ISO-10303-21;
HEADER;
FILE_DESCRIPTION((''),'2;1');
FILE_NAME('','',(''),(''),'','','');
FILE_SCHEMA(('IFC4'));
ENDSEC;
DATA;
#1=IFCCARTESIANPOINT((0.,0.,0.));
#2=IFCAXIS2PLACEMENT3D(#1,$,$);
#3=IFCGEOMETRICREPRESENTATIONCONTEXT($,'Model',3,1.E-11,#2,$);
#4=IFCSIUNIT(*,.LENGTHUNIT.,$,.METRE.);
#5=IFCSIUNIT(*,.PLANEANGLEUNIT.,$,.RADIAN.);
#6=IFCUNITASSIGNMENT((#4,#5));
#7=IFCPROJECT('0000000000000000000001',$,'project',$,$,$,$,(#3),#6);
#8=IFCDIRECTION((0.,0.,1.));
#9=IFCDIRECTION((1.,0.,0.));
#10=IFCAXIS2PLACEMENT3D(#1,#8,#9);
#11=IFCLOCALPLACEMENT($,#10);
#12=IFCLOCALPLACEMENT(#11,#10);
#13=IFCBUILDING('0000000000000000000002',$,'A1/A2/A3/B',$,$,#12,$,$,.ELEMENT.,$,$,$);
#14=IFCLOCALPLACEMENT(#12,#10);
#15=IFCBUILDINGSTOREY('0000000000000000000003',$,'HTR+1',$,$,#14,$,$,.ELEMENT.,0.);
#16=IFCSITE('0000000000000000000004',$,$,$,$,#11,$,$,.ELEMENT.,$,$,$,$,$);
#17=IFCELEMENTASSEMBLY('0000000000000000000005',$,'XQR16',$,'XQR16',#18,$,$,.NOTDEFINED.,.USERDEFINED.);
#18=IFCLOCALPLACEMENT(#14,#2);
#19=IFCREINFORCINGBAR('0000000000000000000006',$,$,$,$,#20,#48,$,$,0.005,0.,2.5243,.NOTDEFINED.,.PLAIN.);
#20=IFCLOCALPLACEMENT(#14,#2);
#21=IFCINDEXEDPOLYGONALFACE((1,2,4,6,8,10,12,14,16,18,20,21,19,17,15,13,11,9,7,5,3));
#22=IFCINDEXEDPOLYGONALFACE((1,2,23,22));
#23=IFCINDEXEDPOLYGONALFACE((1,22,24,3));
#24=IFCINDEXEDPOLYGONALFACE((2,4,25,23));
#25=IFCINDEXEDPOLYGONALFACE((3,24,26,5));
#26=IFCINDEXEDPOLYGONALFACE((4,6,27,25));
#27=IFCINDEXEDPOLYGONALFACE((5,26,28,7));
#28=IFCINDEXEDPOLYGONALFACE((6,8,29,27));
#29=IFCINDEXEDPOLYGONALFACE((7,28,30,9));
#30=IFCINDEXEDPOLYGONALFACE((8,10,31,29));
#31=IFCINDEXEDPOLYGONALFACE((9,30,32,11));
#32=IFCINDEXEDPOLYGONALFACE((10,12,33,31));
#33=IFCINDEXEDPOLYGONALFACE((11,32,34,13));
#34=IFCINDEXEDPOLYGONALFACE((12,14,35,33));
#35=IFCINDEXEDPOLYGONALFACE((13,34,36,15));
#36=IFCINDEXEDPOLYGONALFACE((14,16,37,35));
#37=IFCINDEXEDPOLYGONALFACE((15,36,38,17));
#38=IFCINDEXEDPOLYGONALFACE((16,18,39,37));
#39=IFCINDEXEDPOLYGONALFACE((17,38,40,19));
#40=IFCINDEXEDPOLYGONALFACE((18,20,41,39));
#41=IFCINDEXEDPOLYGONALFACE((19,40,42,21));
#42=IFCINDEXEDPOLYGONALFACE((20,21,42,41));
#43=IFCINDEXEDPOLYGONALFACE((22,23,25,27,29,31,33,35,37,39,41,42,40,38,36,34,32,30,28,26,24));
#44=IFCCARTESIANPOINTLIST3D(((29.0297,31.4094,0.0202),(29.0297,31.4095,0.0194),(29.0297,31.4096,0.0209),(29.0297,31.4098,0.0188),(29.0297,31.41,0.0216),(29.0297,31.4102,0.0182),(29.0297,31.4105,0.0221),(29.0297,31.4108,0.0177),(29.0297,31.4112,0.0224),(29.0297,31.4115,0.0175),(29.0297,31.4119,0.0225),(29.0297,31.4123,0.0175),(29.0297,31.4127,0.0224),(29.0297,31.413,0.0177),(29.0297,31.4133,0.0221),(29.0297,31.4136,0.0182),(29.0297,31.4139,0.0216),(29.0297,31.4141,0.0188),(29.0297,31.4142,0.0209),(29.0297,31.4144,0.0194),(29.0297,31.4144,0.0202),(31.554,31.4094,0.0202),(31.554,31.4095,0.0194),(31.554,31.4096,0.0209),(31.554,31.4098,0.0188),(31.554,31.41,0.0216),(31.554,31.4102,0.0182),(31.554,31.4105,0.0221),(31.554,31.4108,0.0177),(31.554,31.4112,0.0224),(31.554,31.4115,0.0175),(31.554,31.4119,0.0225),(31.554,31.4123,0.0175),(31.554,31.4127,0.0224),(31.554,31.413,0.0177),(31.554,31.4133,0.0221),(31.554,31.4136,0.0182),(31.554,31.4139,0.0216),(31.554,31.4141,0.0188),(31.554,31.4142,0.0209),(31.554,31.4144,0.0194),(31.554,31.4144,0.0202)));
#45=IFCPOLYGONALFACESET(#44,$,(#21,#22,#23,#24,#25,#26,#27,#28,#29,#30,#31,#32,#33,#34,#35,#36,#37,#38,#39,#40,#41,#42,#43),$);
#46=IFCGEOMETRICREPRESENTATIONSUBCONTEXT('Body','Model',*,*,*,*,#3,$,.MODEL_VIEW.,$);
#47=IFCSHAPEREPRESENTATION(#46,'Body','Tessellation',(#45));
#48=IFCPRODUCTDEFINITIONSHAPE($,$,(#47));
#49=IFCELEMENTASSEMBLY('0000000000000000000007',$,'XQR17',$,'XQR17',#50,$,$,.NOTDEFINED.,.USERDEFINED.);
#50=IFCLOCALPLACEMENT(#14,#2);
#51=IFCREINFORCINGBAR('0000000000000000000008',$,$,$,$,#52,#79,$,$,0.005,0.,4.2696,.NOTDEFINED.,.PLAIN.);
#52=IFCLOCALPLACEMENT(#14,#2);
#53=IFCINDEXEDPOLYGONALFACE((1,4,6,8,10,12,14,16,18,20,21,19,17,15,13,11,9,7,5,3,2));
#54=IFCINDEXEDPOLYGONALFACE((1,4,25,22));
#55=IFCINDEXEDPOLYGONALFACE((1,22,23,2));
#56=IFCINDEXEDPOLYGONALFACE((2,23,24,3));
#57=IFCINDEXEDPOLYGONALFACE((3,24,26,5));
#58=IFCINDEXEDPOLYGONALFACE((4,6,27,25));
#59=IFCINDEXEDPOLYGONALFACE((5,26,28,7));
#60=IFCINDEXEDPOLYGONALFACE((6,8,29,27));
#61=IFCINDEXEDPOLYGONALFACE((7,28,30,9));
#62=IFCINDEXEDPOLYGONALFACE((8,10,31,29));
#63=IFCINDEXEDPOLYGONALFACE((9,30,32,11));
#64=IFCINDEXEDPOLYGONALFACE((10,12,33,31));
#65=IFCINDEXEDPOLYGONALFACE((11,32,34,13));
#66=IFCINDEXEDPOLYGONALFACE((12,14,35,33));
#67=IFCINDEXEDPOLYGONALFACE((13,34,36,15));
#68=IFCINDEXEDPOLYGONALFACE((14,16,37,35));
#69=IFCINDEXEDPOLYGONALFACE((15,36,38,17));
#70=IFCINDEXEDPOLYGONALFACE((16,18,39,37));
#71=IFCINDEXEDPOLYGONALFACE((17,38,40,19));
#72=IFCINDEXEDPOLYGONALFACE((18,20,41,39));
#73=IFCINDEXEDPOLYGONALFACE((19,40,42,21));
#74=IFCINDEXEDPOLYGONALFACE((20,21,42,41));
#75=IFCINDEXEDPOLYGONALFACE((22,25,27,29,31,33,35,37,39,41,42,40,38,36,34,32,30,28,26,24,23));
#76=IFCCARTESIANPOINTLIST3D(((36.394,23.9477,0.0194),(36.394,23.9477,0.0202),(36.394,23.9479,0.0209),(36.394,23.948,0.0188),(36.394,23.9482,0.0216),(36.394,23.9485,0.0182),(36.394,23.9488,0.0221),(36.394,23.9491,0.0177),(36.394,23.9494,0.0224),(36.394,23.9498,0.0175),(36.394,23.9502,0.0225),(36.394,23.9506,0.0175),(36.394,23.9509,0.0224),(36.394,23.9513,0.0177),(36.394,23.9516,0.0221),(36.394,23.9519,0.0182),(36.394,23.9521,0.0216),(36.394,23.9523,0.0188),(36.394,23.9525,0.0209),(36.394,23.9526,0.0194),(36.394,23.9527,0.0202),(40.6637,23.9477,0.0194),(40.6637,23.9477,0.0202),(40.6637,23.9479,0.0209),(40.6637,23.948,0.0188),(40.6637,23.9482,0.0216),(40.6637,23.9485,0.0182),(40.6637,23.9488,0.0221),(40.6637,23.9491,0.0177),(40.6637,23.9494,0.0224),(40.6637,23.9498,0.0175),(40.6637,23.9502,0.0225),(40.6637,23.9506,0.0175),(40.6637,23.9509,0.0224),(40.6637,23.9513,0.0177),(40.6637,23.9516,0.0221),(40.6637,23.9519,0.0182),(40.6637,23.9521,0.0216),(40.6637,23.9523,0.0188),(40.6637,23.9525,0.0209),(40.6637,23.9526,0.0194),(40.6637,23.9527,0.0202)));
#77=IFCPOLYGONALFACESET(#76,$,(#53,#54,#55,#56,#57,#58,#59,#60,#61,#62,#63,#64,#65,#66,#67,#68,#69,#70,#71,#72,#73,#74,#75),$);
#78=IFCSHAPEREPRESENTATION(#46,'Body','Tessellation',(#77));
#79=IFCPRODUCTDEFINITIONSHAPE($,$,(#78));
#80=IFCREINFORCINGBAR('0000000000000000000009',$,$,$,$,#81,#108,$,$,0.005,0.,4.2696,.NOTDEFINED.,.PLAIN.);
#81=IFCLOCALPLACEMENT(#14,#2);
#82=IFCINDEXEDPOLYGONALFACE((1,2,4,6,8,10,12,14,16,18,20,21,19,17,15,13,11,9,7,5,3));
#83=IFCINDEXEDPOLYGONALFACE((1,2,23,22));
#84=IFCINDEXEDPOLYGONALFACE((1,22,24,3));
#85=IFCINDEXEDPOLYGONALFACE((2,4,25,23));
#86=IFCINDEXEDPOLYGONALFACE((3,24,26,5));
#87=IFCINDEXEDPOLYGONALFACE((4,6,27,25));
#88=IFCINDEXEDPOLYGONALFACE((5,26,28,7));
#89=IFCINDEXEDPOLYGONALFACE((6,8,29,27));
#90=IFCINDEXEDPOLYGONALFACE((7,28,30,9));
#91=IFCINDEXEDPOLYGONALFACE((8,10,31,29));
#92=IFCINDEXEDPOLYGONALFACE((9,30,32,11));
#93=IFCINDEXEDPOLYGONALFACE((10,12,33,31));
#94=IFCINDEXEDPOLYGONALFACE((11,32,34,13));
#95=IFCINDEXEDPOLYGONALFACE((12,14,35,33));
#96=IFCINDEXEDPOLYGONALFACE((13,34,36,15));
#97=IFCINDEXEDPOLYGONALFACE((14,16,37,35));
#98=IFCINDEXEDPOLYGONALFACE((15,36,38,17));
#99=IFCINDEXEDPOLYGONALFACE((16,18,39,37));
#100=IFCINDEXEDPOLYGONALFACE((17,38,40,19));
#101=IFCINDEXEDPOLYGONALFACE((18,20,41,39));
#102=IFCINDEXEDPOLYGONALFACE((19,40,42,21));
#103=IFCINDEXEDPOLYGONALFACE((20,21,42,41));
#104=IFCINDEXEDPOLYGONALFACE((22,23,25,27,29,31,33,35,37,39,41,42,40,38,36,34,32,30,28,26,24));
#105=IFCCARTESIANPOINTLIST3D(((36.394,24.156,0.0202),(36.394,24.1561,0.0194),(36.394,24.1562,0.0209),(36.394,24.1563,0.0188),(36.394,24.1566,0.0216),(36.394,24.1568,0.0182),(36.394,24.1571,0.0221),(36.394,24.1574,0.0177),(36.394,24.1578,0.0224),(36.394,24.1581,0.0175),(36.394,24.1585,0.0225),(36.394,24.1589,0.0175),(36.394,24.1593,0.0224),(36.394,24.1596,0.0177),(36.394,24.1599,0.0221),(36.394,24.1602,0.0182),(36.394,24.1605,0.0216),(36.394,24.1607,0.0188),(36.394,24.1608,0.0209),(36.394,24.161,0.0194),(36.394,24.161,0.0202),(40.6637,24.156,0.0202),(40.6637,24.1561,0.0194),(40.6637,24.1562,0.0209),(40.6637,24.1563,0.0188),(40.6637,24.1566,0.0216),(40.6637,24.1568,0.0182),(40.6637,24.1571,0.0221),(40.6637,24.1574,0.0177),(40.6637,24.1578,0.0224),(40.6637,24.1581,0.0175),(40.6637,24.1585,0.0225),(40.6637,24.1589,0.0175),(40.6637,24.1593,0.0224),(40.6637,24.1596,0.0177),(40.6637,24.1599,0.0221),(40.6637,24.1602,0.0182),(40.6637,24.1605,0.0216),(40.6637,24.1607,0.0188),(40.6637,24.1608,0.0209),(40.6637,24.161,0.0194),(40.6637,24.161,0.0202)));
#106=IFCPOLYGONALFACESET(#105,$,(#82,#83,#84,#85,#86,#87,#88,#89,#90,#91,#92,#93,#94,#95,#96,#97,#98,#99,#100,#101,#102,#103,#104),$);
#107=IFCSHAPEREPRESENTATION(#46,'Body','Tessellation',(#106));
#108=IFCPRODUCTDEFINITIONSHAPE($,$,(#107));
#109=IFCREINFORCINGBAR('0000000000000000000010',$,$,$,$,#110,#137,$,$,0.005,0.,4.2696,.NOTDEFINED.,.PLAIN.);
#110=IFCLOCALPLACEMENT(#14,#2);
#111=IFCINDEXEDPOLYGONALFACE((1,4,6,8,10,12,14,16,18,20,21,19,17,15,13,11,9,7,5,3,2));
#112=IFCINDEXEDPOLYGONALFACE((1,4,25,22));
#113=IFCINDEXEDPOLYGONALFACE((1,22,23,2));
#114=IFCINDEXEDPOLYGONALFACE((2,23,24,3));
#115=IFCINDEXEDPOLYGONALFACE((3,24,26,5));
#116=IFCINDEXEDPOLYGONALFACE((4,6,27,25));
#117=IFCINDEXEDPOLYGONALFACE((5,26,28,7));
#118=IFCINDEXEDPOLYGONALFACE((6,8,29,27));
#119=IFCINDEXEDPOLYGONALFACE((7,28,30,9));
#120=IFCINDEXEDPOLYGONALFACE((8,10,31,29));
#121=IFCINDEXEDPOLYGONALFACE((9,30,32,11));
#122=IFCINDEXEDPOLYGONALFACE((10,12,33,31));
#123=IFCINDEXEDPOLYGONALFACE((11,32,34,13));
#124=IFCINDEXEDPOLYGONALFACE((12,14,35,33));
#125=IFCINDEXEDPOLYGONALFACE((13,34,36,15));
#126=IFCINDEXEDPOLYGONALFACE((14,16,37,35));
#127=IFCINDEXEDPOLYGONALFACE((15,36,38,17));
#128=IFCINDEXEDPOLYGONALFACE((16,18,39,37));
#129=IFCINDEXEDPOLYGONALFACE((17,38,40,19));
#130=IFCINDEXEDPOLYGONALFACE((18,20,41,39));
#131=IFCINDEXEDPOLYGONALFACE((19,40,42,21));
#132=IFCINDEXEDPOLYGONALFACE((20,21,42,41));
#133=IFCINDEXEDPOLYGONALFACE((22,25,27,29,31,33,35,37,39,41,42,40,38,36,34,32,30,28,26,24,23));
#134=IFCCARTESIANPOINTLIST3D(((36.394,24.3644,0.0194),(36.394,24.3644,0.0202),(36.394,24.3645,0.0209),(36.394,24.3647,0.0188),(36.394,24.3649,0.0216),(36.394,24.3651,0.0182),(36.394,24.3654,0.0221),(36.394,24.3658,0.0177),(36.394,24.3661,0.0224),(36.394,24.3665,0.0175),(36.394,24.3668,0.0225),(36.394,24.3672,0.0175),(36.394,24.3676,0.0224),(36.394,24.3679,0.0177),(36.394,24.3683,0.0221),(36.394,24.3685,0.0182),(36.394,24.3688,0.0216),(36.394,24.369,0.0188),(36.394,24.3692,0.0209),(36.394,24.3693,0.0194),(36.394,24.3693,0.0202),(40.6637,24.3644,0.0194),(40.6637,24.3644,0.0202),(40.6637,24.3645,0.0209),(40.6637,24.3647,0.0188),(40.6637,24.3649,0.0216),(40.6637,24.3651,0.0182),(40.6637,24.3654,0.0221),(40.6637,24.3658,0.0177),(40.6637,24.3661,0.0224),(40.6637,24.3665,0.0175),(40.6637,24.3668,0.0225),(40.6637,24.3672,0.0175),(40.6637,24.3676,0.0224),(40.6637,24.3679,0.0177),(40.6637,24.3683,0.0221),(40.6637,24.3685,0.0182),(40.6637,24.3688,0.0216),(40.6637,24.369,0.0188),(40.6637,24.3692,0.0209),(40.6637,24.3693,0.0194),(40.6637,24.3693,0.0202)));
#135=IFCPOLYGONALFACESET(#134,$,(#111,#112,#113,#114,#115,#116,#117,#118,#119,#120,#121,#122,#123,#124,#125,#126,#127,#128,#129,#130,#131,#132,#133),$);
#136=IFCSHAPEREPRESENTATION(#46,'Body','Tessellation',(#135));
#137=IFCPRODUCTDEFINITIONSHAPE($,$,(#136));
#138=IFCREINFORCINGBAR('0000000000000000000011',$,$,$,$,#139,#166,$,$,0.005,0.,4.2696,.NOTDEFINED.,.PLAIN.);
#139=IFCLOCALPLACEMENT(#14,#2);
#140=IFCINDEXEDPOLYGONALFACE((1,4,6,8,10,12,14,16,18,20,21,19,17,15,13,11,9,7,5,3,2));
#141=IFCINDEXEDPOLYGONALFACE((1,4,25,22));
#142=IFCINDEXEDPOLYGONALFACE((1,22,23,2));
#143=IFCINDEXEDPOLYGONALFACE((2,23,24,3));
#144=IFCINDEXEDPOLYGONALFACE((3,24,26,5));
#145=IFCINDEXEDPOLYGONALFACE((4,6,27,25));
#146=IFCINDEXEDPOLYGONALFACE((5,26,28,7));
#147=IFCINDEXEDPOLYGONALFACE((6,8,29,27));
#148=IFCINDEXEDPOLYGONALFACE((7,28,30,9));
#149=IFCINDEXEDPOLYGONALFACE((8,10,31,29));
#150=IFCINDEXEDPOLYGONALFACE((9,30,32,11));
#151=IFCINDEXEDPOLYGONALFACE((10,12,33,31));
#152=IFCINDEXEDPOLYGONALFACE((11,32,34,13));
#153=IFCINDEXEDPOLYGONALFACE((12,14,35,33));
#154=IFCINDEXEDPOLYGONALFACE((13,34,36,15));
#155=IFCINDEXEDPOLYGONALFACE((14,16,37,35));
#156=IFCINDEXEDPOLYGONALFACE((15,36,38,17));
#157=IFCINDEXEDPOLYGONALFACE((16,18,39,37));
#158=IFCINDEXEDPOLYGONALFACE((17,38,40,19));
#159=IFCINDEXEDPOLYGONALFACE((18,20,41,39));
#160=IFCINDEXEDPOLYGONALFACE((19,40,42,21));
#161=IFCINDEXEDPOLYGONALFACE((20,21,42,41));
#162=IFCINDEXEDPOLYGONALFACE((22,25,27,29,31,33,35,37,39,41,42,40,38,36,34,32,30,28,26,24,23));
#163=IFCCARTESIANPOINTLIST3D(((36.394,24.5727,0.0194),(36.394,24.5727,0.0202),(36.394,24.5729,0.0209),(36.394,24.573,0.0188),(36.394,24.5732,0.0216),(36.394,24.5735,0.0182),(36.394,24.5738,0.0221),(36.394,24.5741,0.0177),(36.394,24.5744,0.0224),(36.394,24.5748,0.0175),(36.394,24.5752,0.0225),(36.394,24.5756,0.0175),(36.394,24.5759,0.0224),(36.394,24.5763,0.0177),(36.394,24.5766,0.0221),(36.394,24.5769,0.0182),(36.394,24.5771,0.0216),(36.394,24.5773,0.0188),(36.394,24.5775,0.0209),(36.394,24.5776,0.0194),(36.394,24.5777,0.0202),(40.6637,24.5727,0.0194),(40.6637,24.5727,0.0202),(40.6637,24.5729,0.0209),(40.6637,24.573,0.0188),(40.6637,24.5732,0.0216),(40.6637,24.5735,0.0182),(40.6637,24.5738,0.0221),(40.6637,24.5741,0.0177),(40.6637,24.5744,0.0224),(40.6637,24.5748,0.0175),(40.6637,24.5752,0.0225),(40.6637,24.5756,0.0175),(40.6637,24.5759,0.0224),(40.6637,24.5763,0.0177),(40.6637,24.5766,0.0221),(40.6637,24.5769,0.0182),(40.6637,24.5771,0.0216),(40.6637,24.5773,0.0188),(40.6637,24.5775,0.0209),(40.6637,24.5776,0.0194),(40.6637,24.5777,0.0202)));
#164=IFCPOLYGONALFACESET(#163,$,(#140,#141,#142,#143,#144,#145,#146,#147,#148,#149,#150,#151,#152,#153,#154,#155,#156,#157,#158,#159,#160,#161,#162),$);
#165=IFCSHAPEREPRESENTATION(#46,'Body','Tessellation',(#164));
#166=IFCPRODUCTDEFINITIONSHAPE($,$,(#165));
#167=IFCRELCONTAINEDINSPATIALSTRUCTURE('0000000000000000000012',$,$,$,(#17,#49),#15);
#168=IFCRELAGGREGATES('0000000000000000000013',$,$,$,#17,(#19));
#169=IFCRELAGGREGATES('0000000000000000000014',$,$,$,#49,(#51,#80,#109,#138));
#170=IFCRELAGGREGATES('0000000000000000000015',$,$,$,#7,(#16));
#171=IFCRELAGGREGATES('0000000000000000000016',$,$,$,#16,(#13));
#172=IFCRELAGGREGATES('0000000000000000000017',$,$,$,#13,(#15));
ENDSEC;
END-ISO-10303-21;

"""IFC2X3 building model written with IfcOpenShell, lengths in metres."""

from ifc_helpers import new_model, entity, si_unit, origin, origin_with_axes, place, context, subcontext, project, spatial, shape, element, aggregate, save


model = new_model("IFC2X3")

# Units and contexts
model_context = context("Model", 3, precision=1e-11, world=origin())
body_context = subcontext(model_context, "Body", "Model", "MODEL_VIEW")
ifc_project = project(units=[si_unit("LENGTHUNIT", "METRE"), si_unit("PLANEANGLEUNIT", "RADIAN")], contexts=[model_context])

# Site, building, storey
site_placement = place(None, origin_with_axes())
site = spatial("IfcSite", under=ifc_project, at=site_placement, CompositionType="ELEMENT")
building_placement = place(site_placement, origin_with_axes())
building = spatial("IfcBuilding", under=site, at=building_placement, Name="A1/A2/A3/B", CompositionType="ELEMENT")
storey_placement = place(building_placement, origin_with_axes())
storey = spatial("IfcBuildingStorey", under=building, at=storey_placement, Name="HTR+1", CompositionType="ELEMENT", Elevation=0.0)

# Element assembly, reinforcing bar
assembly_1_placement = place(storey_placement, origin_with_axes())
assembly_1 = element("IfcElementAssembly", 1, at=assembly_1_placement, inside=storey, Name="XQR16", ObjectType="XQR16", AssemblyPlace="NOTDEFINED", PredefinedType="USERDEFINED")
reinforcing_bar_1_placement = place(assembly_1_placement, origin_with_axes())
reinforcing_bar_1 = element("IfcReinforcingBar", 2, at=reinforcing_bar_1_placement, BarLength=2.5243, BarRole="NOTDEFINED", BarSurface="PLAIN", CrossSectionArea=0.0, NominalDiameter=0.005, shapes=[
    shape(body_context, "Body", "AdvancedSweptSolid", [entity("IfcSweptDiskSolid", entity("IfcPolyline", [entity("IfcCartesianPoint", [29.0297, 31.4119, 0.02]), entity("IfcCartesianPoint", [31.554, 31.4119, 0.02])]), 0.0025, None, 0.0, 2.5243)]),
    shape(body_context, "Body", "AdvancedSweptSolid", [entity("IfcSweptDiskSolid", entity("IfcPolyline", [entity("IfcCartesianPoint", [29.0297, 31.4119, 0.02]), entity("IfcCartesianPoint", [31.554, 31.4119, 0.02])]), 0.0025, None, 0.0, 2.5243)]),
])
aggregate(assembly_1, [reinforcing_bar_1])

# Element assembly, reinforcing bars
assembly_2_placement = place(storey_placement, origin_with_axes())
assembly_2 = element("IfcElementAssembly", 3, at=assembly_2_placement, inside=storey, Name="XQR17", ObjectType="XQR17", AssemblyPlace="NOTDEFINED", PredefinedType="USERDEFINED")
reinforcing_bar_2_placement = place(assembly_2_placement, origin_with_axes())
reinforcing_bar_2 = element("IfcReinforcingBar", 4, at=reinforcing_bar_2_placement, BarLength=4.2696, BarRole="NOTDEFINED", BarSurface="PLAIN", CrossSectionArea=0.0, NominalDiameter=0.005, shapes=[
    shape(body_context, "Body", "AdvancedSweptSolid", [entity("IfcSweptDiskSolid", entity("IfcPolyline", [entity("IfcCartesianPoint", [36.394, 23.9502, 0.02]), entity("IfcCartesianPoint", [40.6637, 23.9502, 0.02])]), 0.0025, None, 0.0, 4.2696)]),
    shape(body_context, "Body", "AdvancedSweptSolid", [entity("IfcSweptDiskSolid", entity("IfcPolyline", [entity("IfcCartesianPoint", [36.394, 23.9502, 0.02]), entity("IfcCartesianPoint", [40.6637, 23.9502, 0.02])]), 0.0025, None, 0.0, 4.2696)]),
])
reinforcing_bar_3_placement = place(assembly_2_placement, origin_with_axes())
reinforcing_bar_3 = element("IfcReinforcingBar", 5, at=reinforcing_bar_3_placement, BarLength=4.2696, BarRole="NOTDEFINED", BarSurface="PLAIN", CrossSectionArea=0.0, NominalDiameter=0.005, shapes=[
    shape(body_context, "Body", "AdvancedSweptSolid", [entity("IfcSweptDiskSolid", entity("IfcPolyline", [entity("IfcCartesianPoint", [36.394, 24.1585, 0.02]), entity("IfcCartesianPoint", [40.6637, 24.1585, 0.02])]), 0.0025, None, 0.0, 4.2696)]),
    shape(body_context, "Body", "AdvancedSweptSolid", [entity("IfcSweptDiskSolid", entity("IfcPolyline", [entity("IfcCartesianPoint", [36.394, 24.1585, 0.02]), entity("IfcCartesianPoint", [40.6637, 24.1585, 0.02])]), 0.0025, None, 0.0, 4.2696)]),
])
reinforcing_bar_4_placement = place(assembly_2_placement, origin_with_axes())
reinforcing_bar_4 = element("IfcReinforcingBar", 6, at=reinforcing_bar_4_placement, BarLength=4.2696, BarRole="NOTDEFINED", BarSurface="PLAIN", CrossSectionArea=0.0, NominalDiameter=0.005, shapes=[
    shape(body_context, "Body", "AdvancedSweptSolid", [entity("IfcSweptDiskSolid", entity("IfcPolyline", [entity("IfcCartesianPoint", [36.394, 24.3668, 0.02]), entity("IfcCartesianPoint", [40.6637, 24.3668, 0.02])]), 0.0025, None, 0.0, 4.2696)]),
    shape(body_context, "Body", "AdvancedSweptSolid", [entity("IfcSweptDiskSolid", entity("IfcPolyline", [entity("IfcCartesianPoint", [36.394, 24.3668, 0.02]), entity("IfcCartesianPoint", [40.6637, 24.3668, 0.02])]), 0.0025, None, 0.0, 4.2696)]),
])
reinforcing_bar_5_placement = place(assembly_2_placement, origin_with_axes())
reinforcing_bar_5 = element("IfcReinforcingBar", 7, at=reinforcing_bar_5_placement, BarLength=4.2696, BarRole="NOTDEFINED", BarSurface="PLAIN", CrossSectionArea=0.0, NominalDiameter=0.005, shapes=[
    shape(body_context, "Body", "AdvancedSweptSolid", [entity("IfcSweptDiskSolid", entity("IfcPolyline", [entity("IfcCartesianPoint", [36.394, 24.5752, 0.02]), entity("IfcCartesianPoint", [40.6637, 24.5752, 0.02])]), 0.0025, None, 0.0, 4.2696)]),
    shape(body_context, "Body", "AdvancedSweptSolid", [entity("IfcSweptDiskSolid", entity("IfcPolyline", [entity("IfcCartesianPoint", [36.394, 24.5752, 0.02]), entity("IfcCartesianPoint", [40.6637, 24.5752, 0.02])]), 0.0025, None, 0.0, 4.2696)]),
])
aggregate(assembly_2, [reinforcing_bar_2, reinforcing_bar_3, reinforcing_bar_4, reinforcing_bar_5])

save(model, "model.ifc")
